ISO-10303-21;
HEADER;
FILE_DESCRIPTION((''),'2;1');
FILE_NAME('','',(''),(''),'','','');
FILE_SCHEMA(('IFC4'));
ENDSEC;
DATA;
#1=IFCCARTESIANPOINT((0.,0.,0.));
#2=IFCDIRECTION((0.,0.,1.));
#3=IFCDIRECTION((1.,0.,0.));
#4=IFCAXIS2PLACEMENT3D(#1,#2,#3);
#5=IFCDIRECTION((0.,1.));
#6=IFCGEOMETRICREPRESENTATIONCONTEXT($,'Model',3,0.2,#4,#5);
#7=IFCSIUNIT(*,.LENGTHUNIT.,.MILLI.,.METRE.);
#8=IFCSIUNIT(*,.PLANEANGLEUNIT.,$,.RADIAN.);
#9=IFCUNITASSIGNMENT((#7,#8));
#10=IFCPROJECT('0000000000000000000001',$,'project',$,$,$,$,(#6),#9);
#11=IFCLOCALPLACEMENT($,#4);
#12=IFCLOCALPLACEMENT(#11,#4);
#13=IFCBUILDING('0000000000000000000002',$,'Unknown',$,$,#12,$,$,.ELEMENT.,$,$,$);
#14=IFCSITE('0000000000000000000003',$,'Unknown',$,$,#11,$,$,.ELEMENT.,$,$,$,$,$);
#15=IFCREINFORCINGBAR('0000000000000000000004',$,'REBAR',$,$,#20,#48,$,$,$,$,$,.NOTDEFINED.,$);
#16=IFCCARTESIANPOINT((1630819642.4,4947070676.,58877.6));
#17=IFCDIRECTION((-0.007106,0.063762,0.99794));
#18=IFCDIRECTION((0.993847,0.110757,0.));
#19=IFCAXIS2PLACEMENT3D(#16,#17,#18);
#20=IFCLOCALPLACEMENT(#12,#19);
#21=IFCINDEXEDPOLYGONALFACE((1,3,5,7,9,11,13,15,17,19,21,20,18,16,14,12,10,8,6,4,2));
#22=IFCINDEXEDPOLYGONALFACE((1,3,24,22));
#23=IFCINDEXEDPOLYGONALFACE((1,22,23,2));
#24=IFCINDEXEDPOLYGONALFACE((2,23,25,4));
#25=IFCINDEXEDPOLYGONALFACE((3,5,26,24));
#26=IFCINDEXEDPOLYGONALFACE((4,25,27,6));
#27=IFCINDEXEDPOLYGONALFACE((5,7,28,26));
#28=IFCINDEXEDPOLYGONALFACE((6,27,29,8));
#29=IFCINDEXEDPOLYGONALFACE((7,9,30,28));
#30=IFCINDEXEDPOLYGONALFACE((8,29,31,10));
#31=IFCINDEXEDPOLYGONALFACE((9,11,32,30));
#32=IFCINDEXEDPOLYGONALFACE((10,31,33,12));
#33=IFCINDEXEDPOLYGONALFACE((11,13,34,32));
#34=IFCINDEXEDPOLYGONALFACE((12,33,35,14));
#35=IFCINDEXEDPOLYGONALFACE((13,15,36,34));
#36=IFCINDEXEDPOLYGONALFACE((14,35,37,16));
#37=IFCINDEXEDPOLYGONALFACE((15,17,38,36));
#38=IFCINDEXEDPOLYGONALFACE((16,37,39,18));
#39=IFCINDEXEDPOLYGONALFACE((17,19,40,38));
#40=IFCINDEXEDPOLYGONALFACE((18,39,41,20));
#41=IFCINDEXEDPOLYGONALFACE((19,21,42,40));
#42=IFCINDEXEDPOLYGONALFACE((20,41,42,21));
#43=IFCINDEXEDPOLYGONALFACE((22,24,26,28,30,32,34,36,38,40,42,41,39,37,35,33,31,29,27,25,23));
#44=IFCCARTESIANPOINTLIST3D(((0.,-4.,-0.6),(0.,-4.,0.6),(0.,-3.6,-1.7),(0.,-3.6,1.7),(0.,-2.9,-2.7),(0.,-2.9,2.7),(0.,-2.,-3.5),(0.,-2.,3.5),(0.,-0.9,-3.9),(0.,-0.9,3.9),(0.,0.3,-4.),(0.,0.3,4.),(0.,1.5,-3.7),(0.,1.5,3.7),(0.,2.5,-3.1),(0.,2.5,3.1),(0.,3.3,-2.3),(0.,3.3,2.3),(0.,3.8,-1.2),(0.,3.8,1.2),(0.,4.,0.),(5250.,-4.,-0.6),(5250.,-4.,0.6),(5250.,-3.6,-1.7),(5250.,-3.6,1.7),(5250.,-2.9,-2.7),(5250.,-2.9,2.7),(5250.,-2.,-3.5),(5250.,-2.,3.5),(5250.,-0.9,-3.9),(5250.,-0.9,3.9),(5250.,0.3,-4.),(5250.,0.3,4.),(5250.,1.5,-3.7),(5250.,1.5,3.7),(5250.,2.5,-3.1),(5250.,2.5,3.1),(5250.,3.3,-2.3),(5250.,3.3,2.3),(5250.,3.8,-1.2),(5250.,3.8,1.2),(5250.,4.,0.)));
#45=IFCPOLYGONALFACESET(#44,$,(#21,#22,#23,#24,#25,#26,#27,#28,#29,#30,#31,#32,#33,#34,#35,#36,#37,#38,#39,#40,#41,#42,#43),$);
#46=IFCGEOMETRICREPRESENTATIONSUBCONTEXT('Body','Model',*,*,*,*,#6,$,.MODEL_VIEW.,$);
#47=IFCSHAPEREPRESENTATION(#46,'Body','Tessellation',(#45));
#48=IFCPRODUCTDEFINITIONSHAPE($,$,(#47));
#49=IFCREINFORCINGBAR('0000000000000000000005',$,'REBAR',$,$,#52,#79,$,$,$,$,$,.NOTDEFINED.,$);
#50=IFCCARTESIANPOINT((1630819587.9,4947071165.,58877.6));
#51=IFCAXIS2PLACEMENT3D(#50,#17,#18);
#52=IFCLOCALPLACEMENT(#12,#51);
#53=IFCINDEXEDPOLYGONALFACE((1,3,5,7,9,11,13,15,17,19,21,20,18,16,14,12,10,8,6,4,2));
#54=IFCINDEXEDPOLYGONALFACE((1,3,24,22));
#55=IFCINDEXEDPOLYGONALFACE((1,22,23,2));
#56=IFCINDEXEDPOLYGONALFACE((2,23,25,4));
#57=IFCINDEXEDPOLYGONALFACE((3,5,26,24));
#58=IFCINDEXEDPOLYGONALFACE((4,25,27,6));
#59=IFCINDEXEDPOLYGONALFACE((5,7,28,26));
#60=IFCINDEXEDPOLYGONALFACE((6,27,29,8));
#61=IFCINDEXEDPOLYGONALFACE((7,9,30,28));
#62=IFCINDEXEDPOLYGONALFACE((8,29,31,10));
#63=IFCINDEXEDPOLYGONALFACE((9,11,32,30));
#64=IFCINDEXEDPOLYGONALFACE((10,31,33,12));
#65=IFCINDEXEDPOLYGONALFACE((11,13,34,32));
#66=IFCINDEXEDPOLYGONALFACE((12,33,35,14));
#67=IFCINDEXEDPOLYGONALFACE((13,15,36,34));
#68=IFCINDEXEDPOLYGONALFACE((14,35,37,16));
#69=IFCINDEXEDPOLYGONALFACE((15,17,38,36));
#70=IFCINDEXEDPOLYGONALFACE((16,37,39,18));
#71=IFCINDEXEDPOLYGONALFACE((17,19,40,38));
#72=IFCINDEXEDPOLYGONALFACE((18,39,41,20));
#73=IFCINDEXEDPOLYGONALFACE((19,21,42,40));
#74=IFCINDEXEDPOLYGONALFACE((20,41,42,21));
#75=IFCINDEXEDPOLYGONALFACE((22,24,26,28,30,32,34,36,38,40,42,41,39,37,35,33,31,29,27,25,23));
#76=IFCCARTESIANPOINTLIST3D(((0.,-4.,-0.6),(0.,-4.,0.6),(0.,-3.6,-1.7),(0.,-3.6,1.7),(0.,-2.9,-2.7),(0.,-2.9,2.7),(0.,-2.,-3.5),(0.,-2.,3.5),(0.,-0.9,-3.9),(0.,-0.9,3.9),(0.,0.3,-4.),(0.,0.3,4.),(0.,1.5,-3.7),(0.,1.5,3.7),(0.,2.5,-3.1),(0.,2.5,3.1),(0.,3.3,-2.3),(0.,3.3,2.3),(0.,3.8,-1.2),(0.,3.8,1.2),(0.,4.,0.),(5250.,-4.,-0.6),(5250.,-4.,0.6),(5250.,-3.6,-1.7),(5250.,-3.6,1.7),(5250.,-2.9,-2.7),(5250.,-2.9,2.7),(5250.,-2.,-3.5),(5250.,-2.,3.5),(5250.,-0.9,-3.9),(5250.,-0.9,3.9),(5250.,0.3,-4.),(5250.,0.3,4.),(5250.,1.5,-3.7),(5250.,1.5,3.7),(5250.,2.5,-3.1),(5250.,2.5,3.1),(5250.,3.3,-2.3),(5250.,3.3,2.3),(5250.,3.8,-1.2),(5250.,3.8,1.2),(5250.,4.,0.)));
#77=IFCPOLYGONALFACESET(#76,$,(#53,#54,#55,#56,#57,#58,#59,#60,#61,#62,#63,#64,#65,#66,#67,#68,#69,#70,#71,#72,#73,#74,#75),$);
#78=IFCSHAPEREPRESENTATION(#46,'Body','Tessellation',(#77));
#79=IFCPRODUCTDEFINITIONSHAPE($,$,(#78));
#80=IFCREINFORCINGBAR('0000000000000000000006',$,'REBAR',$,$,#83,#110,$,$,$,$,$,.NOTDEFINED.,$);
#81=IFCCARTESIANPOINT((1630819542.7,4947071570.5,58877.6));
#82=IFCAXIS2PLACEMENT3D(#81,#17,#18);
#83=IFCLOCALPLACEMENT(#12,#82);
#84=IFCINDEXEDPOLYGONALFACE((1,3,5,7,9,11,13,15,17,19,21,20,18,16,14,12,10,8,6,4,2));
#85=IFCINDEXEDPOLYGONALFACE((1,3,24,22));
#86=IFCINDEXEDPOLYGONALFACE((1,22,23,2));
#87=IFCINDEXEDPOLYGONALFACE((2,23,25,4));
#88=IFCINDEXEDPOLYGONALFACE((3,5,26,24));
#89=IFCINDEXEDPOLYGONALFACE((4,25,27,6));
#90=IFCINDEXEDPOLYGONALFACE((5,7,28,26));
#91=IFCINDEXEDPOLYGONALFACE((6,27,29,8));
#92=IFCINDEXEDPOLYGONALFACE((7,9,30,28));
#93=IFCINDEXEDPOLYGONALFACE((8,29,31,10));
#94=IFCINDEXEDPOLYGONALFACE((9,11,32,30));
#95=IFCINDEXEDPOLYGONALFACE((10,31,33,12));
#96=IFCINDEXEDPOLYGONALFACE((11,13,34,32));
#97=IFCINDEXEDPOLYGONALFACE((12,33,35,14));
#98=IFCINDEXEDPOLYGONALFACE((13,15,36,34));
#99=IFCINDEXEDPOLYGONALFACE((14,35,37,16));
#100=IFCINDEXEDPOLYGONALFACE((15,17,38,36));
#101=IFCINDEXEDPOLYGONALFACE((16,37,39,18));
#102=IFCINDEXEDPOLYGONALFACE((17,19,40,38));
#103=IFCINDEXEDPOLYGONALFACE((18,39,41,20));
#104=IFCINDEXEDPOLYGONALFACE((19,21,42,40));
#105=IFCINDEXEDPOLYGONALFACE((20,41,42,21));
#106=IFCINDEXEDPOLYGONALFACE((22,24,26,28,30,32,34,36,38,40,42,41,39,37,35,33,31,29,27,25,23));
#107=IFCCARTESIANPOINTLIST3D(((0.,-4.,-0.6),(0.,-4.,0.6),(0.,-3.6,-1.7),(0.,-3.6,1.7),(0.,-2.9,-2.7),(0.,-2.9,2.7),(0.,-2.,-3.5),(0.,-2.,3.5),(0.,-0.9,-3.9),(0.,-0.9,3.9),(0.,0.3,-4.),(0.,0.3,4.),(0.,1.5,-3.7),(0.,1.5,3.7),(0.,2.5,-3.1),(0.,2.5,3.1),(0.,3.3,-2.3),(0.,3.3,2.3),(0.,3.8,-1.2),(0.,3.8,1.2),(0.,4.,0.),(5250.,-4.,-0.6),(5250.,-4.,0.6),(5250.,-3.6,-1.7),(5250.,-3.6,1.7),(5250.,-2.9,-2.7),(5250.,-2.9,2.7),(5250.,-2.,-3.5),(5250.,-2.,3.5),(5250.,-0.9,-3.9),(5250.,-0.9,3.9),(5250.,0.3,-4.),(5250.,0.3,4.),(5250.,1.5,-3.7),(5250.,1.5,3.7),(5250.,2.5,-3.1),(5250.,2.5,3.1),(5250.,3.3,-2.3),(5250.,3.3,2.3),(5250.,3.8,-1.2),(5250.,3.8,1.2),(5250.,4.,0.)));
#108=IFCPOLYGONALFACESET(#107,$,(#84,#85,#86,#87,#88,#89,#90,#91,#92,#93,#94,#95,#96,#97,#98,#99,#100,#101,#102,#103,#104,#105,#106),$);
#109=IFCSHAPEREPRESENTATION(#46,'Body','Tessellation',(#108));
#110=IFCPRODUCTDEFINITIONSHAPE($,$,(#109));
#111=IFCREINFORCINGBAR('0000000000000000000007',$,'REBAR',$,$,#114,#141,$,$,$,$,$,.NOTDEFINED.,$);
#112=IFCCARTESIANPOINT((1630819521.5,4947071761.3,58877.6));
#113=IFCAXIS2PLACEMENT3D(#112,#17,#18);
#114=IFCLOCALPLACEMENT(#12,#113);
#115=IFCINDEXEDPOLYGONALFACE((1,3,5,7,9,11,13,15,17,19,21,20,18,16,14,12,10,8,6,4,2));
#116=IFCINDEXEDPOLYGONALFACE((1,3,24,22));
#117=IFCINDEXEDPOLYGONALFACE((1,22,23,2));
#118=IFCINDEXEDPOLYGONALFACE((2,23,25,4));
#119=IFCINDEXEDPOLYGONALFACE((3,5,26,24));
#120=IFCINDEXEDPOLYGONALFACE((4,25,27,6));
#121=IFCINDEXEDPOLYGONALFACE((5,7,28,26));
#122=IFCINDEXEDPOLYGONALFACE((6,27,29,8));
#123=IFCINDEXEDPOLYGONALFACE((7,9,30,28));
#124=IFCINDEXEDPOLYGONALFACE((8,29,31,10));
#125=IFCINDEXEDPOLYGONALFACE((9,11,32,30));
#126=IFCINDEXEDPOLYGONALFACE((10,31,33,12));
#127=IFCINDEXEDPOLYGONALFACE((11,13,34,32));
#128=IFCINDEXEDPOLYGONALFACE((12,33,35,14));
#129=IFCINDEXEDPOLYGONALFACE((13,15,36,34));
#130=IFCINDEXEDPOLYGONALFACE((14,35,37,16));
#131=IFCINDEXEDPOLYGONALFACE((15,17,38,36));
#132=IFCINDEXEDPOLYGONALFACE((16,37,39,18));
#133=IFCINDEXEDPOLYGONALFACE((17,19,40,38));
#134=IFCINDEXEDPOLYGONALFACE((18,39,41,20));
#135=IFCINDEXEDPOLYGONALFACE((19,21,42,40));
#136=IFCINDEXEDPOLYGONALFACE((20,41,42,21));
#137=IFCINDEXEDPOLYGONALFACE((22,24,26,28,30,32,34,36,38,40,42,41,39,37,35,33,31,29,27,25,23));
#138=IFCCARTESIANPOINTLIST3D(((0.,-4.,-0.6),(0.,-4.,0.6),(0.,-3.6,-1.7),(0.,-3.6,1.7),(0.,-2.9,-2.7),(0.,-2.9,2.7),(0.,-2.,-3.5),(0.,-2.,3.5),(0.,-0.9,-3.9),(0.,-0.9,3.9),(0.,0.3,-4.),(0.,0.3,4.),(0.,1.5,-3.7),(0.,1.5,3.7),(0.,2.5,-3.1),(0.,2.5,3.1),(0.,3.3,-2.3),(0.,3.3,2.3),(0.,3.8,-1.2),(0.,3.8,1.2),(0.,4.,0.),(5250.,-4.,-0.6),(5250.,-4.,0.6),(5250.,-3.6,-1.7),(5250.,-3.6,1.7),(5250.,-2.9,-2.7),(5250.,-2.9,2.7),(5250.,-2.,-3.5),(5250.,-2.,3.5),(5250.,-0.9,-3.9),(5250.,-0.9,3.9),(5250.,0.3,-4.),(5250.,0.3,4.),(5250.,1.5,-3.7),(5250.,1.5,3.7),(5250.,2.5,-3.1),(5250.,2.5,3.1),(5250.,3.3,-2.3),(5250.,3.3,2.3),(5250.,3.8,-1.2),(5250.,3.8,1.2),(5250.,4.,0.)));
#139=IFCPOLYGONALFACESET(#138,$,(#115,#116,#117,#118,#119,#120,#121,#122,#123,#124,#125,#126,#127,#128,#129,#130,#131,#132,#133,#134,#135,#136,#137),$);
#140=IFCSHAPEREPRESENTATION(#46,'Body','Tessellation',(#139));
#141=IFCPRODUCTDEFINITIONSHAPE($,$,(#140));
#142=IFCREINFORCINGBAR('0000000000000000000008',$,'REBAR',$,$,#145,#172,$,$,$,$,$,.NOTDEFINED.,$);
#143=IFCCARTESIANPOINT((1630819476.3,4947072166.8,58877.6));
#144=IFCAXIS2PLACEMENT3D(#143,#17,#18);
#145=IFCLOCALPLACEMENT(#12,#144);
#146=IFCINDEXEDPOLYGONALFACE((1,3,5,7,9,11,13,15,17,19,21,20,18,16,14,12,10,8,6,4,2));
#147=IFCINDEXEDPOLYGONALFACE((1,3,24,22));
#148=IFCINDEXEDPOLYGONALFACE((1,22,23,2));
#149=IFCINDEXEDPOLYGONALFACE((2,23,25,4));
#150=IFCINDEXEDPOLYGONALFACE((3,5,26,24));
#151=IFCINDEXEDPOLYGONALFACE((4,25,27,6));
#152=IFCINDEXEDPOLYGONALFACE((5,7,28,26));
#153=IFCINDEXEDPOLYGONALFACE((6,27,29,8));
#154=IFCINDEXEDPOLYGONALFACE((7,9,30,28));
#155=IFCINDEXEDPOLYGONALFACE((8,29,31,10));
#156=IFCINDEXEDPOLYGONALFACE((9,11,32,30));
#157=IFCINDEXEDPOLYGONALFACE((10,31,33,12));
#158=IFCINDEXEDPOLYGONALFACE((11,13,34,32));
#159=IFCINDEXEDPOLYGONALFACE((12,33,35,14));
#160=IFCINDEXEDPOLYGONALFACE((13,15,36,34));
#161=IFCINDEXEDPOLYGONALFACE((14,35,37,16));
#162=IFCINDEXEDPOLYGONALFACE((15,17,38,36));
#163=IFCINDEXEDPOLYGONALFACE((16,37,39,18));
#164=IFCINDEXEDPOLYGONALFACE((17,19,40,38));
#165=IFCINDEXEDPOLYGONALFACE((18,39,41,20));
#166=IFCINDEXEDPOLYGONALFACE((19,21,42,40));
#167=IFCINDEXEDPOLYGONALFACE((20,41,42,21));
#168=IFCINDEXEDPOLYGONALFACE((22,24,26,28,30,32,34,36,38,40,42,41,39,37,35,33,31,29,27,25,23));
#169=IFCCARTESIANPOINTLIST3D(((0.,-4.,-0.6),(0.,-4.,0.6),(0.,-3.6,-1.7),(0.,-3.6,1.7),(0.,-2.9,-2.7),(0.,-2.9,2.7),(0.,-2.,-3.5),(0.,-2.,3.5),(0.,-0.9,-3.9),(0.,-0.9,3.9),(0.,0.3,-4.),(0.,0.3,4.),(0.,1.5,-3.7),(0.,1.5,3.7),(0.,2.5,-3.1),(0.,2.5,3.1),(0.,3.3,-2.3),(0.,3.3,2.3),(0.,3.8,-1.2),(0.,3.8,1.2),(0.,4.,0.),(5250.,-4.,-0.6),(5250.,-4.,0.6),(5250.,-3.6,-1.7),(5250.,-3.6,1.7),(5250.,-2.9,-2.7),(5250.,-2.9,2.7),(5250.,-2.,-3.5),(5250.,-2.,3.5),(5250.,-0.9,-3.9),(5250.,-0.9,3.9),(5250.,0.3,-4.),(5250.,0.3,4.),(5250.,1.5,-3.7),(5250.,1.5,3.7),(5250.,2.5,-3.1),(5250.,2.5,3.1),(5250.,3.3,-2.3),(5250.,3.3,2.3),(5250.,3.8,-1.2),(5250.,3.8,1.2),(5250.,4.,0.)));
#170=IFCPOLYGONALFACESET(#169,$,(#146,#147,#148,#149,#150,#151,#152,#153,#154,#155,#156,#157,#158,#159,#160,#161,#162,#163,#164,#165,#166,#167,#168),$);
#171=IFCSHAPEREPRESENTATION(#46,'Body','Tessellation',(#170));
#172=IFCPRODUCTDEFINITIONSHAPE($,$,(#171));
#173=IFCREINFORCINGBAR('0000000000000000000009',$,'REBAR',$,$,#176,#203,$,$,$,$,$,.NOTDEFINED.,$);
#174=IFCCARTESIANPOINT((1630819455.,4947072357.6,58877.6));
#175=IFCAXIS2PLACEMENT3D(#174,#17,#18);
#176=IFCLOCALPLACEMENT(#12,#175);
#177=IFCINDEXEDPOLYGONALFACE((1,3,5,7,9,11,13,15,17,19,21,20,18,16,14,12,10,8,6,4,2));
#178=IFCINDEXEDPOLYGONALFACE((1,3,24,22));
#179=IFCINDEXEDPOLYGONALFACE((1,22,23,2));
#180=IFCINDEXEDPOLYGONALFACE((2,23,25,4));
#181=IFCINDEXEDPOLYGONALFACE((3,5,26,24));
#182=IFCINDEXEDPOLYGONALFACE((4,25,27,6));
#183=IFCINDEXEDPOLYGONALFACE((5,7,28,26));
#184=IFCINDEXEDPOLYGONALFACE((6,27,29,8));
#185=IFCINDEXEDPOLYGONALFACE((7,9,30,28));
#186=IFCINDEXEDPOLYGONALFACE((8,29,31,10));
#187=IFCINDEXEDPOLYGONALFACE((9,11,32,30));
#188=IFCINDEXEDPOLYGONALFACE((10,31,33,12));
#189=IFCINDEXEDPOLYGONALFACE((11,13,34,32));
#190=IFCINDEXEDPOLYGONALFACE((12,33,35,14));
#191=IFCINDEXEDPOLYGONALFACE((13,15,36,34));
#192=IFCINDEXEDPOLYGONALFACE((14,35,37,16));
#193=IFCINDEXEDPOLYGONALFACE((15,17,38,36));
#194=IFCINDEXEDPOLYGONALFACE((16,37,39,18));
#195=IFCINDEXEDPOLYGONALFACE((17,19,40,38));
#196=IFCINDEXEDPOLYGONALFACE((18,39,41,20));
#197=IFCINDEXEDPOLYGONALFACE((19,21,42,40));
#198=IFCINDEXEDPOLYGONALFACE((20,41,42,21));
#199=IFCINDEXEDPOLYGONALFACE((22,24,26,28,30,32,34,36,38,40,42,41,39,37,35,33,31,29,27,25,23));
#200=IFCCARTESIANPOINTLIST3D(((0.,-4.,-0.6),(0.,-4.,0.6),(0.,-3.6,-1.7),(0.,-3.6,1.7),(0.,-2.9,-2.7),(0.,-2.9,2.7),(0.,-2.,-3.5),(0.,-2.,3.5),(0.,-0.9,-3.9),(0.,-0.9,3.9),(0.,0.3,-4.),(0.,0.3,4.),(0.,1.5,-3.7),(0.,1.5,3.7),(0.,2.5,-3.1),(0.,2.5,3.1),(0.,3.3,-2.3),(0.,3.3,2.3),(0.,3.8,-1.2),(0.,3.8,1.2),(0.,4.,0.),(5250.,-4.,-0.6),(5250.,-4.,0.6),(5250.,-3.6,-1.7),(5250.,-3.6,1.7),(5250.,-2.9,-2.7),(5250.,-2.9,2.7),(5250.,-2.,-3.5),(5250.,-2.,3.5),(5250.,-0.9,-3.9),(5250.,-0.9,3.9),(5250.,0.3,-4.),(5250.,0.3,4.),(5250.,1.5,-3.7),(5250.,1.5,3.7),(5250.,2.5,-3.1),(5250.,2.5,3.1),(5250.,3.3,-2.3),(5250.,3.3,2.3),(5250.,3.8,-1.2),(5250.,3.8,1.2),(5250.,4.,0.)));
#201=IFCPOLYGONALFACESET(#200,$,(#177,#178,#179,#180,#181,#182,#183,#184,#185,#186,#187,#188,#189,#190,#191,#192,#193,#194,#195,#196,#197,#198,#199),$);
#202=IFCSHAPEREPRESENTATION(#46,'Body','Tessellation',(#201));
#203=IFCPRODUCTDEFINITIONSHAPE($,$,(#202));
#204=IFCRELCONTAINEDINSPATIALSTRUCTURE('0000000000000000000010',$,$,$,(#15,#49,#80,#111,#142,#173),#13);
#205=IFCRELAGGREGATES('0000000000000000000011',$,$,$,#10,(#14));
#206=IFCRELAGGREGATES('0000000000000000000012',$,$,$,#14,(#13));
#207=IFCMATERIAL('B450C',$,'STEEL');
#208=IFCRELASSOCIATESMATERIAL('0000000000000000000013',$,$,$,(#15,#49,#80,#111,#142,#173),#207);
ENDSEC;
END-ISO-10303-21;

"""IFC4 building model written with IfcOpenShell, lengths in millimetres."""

from ifc_helpers import new_model, entity, si_unit, direction, frame, origin_with_axes, place, context, subcontext, project, spatial, material, element, save


model = new_model("IFC4")

# Units and contexts
model_context = context("Model", 3, precision=0.2, world=origin_with_axes(), true_north=direction((0.0, 1.0)))
body_context = subcontext(model_context, "Body", "Model", "MODEL_VIEW")
ifc_project = project(units=[si_unit("LENGTHUNIT", "METRE", prefix="MILLI"), si_unit("PLANEANGLEUNIT", "RADIAN")], contexts=[model_context])

# Site, building
site_placement = place(None, origin_with_axes())
site = spatial("IfcSite", under=ifc_project, at=site_placement, Name="Unknown", CompositionType="ELEMENT")
building_placement = place(site_placement, origin_with_axes())
building = spatial("IfcBuilding", under=site, at=building_placement, Name="Unknown", CompositionType="ELEMENT")

# Reinforcing bars
ifc_material = material(Name="B450C", Category="STEEL")
for number, where, z_axis, x_axis, name in (
    (1, (1630819642.4, 4947070676.0, 58877.6), (-0.007106, 0.063762, 0.99794), (0.993847, 0.110757, 0.0), "REBAR"),
    (2, (1630819587.9, 4947071165.0, 58877.6), (-0.007106, 0.063762, 0.99794), (0.993847, 0.110757, 0.0), "REBAR"),
):
    element("IfcReinforcingBar", number, at=place(building_placement, frame(where, z_axis=z_axis, x_axis=x_axis)), inside=building, material=ifc_material, Name=name, PredefinedType="NOTDEFINED", context=body_context, shape_type="AdvancedSweptSolid", body=[
        entity("IfcSweptDiskSolid", entity("IfcIndexedPolyCurve", entity("IfcCartesianPointList3D", [[0.0, 0.0, 0.0], [5250.0, 0.0, 0.0]]), [entity("IfcLineIndex", [1, 2])]), 4.0),
    ])
for number, where, z_axis, x_axis, name in (
    (3, (1630819542.7, 4947071570.5, 58877.6), (-0.007106, 0.063762, 0.99794), (0.993847, 0.110757, 0.0), "REBAR"),
    (4, (1630819521.5, 4947071761.3, 58877.6), (-0.007106, 0.063762, 0.99794), (0.993847, 0.110757, 0.0), "REBAR"),
    (5, (1630819476.3, 4947072166.8, 58877.6), (-0.007106, 0.063762, 0.99794), (0.993847, 0.110757, 0.0), "REBAR"),
    (6, (1630819455.0, 4947072357.6, 58877.6), (-0.007106, 0.063762, 0.99794), (0.993847, 0.110757, 0.0), "REBAR"),
):
    element("IfcReinforcingBar", number, at=place(building_placement, frame(where, z_axis=z_axis, x_axis=x_axis)), inside=building, material=ifc_material, Name=name, PredefinedType="NOTDEFINED", context=body_context, shape_type="AdvancedSweptSolid", body=[
        entity("IfcSweptDiskSolid", entity("IfcIndexedPolyCurve", entity("IfcCartesianPointList3D", [[0.0, 0.0, 0.0], [5250.0, 0.0, 0.0]]), [entity("IfcLineIndex", [1, 2])]), 4.0),
    ])

save(model, "model.ifc")
